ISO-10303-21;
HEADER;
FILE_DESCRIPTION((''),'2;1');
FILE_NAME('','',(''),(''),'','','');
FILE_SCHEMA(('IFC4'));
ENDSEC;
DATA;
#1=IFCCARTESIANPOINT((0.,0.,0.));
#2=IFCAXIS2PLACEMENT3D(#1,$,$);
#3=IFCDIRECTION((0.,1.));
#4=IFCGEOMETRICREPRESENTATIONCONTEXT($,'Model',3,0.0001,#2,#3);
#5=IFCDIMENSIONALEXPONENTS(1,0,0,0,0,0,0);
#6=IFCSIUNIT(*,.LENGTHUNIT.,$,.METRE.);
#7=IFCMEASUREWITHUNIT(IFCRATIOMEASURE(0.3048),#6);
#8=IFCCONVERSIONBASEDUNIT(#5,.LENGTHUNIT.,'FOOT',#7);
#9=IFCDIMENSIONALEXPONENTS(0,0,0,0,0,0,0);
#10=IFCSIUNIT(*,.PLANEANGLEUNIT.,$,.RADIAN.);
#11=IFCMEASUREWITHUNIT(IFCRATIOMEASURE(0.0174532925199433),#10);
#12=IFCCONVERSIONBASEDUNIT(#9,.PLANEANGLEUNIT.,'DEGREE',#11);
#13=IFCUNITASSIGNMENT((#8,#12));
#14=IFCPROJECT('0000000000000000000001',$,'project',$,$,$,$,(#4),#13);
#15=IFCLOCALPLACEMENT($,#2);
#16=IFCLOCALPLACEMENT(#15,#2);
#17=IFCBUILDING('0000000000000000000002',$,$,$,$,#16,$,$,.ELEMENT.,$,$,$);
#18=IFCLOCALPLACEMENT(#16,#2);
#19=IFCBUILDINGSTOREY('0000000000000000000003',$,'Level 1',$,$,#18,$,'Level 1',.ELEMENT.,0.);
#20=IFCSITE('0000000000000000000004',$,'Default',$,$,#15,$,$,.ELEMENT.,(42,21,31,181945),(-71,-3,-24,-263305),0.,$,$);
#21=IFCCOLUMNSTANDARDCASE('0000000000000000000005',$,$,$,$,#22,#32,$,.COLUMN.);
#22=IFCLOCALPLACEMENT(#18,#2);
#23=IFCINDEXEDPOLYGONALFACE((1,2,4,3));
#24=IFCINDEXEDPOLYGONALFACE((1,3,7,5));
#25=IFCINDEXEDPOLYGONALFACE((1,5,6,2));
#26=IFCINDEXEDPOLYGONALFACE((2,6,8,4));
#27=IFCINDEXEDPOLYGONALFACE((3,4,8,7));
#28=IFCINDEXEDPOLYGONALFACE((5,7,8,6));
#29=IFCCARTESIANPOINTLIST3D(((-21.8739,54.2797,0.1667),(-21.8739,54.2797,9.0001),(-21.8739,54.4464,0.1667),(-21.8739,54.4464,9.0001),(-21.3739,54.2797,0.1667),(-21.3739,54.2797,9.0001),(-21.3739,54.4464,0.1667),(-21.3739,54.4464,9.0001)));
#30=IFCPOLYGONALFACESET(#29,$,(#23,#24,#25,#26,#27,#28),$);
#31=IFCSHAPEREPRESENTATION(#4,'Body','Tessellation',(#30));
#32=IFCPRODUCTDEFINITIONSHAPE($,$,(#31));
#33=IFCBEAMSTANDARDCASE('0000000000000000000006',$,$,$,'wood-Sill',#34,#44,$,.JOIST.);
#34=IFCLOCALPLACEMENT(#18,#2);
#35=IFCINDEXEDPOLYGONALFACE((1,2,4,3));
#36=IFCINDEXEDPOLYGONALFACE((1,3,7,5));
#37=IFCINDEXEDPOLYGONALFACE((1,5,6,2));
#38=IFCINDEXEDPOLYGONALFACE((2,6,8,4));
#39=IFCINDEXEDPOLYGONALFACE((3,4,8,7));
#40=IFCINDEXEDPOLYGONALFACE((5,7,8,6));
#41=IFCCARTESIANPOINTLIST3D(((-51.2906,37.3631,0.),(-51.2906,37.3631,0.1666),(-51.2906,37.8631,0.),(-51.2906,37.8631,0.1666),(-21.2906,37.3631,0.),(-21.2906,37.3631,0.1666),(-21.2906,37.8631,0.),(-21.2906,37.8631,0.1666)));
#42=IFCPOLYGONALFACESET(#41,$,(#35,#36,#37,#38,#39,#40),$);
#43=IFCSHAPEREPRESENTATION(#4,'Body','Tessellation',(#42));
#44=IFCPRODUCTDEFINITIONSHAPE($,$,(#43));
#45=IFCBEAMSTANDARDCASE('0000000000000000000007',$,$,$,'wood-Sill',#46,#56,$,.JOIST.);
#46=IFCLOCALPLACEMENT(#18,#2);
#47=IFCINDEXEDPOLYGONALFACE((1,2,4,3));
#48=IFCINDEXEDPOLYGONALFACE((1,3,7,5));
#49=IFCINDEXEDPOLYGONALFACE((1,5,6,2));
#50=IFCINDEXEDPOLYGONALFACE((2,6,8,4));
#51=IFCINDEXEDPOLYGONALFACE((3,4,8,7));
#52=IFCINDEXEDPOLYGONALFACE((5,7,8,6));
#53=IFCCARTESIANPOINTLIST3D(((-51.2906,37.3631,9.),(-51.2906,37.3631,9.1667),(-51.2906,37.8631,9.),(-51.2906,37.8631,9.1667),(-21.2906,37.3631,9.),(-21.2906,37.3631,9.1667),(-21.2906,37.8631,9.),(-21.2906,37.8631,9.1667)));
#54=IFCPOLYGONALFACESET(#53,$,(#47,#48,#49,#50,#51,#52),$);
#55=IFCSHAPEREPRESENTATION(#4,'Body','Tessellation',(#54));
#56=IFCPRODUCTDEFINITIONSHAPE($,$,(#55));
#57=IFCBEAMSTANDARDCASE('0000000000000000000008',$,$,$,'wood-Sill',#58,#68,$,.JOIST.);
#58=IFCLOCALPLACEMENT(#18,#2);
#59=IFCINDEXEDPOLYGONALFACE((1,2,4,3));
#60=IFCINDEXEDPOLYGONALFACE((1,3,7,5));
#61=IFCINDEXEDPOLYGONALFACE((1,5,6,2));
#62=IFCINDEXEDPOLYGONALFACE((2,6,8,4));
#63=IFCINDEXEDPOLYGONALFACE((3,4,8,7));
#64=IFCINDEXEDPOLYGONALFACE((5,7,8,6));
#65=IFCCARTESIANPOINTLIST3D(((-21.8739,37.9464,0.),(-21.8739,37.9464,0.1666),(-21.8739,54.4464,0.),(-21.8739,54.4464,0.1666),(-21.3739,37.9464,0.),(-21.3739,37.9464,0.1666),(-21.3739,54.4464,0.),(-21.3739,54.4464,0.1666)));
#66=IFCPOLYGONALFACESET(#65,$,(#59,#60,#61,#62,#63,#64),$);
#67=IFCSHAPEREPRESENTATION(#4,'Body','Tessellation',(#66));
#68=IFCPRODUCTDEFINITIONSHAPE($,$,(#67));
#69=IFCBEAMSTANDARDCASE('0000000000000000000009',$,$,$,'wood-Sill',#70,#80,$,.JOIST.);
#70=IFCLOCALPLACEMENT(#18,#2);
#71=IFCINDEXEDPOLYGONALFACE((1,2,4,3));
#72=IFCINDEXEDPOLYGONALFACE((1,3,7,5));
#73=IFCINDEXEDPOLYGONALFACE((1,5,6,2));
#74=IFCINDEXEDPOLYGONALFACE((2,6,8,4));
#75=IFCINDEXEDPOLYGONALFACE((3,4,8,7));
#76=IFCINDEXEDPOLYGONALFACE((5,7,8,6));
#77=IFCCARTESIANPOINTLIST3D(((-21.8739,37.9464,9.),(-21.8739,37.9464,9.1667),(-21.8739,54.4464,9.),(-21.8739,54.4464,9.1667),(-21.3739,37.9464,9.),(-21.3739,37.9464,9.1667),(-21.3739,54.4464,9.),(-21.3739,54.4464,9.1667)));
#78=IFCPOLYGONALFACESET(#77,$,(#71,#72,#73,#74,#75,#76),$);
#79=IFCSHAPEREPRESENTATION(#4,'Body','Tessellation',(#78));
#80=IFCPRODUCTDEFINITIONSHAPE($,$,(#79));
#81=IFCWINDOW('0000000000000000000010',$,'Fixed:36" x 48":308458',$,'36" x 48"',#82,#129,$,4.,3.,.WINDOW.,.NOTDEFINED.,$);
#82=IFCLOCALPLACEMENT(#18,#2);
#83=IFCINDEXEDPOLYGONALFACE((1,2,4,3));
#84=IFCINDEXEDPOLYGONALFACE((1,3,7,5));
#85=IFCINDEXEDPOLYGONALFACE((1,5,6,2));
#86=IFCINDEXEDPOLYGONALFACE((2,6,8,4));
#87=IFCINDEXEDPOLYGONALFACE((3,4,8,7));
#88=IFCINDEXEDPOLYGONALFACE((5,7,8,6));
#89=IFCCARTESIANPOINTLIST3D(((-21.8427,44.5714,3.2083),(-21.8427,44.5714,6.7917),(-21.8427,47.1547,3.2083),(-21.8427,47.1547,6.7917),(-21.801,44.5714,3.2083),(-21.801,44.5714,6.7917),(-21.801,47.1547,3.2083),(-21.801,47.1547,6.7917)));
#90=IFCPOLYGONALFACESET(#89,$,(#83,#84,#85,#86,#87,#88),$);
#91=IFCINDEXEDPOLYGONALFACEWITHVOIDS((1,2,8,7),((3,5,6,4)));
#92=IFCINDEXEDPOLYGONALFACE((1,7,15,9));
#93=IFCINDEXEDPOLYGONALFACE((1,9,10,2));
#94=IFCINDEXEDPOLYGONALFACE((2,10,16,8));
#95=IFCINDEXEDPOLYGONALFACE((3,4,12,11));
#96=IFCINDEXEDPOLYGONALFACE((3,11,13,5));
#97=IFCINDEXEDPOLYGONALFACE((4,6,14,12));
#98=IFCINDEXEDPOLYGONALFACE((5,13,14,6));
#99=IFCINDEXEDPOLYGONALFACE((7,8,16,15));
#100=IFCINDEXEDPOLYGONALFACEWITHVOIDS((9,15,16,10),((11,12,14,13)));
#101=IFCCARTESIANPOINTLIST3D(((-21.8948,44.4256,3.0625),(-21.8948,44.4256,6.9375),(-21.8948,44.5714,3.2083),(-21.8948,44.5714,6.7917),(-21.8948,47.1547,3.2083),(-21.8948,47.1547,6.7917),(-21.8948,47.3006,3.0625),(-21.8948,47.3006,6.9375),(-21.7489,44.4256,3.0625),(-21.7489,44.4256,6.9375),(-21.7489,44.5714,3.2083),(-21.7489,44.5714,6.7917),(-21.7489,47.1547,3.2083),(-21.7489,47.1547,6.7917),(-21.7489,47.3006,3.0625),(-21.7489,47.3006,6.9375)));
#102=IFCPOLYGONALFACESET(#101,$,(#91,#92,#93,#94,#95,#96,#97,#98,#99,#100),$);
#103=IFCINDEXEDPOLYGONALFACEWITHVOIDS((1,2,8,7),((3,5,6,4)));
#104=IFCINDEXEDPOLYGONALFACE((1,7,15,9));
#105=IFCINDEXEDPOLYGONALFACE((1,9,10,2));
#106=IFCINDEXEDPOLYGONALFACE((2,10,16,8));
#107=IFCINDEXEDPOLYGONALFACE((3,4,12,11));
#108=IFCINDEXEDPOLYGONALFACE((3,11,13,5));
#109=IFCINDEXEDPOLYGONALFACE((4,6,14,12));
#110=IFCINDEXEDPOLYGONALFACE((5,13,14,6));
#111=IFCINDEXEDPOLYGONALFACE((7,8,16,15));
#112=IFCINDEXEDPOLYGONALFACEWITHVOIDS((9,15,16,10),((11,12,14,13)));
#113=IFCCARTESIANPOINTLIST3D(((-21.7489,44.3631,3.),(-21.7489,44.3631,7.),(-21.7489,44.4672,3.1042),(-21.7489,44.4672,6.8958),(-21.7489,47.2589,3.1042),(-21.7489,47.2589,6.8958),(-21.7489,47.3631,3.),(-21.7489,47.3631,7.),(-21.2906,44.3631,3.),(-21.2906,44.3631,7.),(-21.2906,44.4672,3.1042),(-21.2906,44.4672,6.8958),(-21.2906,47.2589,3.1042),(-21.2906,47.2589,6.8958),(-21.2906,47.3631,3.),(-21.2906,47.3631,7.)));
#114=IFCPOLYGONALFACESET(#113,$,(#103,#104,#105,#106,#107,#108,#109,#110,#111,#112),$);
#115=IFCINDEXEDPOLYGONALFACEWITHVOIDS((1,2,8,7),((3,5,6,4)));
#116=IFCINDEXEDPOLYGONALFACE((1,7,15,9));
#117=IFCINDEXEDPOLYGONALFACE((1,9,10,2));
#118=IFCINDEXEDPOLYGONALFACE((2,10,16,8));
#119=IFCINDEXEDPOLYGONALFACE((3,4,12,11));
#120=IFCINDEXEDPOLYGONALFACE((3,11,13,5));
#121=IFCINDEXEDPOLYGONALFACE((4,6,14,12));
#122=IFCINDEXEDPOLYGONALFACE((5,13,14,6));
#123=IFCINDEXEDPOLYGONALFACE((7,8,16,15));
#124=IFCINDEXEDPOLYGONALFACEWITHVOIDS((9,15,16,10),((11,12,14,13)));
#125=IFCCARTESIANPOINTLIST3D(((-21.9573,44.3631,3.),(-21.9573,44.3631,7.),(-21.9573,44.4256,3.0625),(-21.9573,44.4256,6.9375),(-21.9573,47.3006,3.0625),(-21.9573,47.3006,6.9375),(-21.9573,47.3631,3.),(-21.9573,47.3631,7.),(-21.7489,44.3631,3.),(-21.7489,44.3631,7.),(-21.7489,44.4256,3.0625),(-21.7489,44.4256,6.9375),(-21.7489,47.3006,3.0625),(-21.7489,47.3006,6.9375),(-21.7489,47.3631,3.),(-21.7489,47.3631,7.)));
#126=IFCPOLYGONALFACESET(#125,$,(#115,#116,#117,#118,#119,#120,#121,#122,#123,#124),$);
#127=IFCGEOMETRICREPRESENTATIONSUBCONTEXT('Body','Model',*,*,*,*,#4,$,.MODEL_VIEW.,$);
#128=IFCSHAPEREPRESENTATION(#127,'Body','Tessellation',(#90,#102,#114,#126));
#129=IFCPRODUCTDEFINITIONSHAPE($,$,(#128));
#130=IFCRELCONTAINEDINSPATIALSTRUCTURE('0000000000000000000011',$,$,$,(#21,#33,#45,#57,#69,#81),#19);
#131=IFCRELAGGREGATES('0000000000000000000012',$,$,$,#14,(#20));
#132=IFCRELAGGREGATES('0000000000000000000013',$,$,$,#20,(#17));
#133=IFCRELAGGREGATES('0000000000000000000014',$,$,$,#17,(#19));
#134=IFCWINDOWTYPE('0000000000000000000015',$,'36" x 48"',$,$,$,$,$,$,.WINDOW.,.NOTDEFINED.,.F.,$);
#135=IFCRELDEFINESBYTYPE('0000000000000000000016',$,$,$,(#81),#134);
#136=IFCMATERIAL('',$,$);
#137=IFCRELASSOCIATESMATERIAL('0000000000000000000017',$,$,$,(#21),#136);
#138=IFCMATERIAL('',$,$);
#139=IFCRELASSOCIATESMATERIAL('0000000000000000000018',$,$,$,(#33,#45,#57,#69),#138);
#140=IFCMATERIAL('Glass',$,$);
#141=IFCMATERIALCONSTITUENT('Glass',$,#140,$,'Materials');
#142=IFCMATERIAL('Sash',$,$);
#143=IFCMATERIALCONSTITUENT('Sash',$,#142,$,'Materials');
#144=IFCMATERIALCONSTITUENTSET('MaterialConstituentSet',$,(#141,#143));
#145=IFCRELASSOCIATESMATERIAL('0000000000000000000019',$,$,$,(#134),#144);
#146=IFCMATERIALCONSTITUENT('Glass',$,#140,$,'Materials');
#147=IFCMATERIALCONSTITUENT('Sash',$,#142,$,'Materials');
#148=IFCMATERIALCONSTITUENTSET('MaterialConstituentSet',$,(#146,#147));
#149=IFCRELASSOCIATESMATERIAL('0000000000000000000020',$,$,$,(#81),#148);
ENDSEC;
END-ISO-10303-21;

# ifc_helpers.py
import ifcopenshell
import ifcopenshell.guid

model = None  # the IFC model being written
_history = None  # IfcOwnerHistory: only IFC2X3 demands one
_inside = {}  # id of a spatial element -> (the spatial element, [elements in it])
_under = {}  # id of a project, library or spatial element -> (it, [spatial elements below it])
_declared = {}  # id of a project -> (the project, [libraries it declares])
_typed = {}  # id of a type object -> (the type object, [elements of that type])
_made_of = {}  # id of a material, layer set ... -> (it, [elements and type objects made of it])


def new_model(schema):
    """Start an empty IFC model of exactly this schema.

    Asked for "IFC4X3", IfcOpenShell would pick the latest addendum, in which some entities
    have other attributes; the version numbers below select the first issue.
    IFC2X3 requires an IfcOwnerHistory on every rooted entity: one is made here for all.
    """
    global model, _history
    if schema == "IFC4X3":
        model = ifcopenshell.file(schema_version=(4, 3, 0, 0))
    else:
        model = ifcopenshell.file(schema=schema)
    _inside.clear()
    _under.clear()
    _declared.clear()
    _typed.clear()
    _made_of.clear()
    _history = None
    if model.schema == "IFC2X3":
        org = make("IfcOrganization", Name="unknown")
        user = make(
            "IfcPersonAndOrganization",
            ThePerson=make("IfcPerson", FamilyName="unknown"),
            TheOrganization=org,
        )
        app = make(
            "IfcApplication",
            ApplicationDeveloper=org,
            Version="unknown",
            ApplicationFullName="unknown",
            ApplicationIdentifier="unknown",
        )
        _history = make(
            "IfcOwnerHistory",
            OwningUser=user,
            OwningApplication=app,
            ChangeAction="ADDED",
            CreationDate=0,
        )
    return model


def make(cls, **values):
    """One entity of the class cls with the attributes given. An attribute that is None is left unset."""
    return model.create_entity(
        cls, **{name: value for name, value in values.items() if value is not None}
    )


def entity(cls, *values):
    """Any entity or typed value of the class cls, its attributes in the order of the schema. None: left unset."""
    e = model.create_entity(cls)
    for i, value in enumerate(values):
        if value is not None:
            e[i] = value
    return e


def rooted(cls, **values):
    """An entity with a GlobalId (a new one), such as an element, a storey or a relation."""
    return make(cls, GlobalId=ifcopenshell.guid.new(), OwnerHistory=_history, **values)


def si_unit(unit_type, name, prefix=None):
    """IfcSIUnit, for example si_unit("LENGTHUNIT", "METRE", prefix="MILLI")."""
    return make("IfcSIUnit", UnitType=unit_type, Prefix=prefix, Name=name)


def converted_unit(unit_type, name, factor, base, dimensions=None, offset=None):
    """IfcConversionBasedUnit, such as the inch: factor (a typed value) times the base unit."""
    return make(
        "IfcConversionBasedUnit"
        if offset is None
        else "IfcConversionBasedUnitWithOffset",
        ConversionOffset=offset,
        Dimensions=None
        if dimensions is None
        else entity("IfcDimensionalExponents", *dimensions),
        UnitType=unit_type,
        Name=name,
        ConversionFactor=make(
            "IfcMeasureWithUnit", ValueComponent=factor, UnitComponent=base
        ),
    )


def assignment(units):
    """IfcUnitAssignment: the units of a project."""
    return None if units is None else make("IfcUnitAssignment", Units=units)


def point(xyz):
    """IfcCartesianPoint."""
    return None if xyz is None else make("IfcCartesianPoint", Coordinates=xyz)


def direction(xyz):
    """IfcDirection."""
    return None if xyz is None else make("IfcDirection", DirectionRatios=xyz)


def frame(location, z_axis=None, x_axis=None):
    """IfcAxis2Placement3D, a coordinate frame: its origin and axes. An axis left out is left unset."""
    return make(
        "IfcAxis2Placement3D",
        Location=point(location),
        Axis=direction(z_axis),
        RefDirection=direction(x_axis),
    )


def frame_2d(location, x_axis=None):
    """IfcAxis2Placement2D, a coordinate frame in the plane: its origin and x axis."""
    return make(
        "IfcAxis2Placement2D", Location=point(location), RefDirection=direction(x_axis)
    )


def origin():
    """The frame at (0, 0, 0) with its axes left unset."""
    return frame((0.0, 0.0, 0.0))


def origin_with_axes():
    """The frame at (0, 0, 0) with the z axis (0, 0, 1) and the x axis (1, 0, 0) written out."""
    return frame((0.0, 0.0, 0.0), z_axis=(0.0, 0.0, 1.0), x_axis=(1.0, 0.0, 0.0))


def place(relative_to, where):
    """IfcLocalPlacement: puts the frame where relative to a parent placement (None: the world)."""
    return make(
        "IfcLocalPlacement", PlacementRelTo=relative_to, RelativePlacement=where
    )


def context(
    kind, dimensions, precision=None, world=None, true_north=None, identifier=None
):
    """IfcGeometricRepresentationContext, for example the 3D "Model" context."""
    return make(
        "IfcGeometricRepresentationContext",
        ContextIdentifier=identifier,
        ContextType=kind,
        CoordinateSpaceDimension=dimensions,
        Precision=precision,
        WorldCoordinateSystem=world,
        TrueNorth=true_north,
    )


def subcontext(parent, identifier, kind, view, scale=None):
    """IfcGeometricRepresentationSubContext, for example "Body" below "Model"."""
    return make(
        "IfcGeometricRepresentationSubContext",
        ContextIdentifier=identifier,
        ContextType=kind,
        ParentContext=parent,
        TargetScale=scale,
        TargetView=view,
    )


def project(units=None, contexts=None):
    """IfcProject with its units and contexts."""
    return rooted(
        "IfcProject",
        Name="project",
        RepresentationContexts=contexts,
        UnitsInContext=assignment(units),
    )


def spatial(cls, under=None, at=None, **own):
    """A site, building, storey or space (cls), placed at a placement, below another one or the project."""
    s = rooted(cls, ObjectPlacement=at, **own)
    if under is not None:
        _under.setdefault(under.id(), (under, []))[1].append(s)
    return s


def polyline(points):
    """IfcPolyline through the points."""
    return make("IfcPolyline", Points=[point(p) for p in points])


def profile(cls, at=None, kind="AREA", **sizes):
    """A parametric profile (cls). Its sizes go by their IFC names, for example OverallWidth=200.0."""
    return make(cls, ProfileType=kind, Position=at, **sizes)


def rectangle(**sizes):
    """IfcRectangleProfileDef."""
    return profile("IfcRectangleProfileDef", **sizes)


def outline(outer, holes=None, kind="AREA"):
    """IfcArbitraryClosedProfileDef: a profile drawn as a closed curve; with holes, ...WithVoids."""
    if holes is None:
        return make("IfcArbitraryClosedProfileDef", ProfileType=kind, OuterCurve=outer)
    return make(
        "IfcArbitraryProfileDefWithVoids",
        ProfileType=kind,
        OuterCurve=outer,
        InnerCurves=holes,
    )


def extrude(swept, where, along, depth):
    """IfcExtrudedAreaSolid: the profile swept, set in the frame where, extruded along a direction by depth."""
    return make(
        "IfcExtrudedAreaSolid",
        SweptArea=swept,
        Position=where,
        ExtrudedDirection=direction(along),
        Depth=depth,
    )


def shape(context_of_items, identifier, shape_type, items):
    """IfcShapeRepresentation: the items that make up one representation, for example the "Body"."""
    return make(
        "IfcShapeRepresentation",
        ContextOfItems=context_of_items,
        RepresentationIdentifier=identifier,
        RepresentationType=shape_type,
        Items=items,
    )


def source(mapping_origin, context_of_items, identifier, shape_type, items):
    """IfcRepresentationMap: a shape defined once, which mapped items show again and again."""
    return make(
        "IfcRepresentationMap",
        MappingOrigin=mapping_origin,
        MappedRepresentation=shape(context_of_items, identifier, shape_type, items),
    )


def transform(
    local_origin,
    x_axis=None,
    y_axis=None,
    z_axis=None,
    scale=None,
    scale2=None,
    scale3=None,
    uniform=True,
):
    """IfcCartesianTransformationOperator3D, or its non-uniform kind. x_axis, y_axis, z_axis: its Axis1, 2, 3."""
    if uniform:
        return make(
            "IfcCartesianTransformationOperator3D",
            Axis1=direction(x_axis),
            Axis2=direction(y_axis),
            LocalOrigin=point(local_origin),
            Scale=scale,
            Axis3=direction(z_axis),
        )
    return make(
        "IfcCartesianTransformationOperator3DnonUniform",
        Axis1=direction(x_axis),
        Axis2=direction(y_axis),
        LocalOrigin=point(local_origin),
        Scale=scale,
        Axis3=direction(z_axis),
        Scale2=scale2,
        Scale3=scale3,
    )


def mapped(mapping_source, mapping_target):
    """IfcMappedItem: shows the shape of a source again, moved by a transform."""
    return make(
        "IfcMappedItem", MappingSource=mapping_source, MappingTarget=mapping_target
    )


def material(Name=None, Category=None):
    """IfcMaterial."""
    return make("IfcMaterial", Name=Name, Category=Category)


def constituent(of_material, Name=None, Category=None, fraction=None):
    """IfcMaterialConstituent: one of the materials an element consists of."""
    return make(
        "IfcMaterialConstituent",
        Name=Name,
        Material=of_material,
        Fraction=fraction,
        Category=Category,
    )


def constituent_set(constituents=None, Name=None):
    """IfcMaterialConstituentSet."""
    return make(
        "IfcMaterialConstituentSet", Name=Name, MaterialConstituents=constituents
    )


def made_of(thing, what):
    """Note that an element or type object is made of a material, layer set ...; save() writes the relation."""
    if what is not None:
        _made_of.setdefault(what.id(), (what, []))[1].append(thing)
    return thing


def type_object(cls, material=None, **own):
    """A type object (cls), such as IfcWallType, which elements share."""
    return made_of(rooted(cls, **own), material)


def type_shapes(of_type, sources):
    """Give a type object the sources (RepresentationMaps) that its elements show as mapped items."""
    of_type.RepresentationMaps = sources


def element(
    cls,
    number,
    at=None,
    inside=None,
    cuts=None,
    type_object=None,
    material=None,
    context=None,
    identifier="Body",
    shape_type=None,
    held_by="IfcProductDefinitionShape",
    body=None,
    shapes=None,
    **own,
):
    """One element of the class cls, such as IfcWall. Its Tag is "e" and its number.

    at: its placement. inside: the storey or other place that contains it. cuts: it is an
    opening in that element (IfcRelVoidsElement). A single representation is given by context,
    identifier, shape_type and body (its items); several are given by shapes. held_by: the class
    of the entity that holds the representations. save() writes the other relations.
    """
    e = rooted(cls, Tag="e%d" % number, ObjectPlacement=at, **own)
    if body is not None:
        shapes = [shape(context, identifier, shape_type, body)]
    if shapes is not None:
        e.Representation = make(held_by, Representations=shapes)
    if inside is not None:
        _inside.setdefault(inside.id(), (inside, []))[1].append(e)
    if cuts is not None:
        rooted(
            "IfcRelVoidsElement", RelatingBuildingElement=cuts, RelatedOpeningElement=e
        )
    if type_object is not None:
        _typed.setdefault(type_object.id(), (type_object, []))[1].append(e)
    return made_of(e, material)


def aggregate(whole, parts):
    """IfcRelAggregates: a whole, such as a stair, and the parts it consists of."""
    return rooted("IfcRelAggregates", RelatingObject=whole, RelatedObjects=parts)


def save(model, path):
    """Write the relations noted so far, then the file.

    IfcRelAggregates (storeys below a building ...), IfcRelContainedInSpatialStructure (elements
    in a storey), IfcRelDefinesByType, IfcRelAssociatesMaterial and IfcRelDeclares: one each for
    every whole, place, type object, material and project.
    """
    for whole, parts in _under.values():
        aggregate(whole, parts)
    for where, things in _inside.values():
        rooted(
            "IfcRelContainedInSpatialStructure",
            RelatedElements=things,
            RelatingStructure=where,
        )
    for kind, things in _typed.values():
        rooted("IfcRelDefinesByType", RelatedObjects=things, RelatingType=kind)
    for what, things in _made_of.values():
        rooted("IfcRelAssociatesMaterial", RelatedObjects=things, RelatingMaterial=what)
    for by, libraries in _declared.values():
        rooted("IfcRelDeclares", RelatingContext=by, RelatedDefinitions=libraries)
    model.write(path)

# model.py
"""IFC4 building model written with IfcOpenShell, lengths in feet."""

from ifc_helpers import new_model, entity, si_unit, converted_unit, direction, frame, frame_2d, origin, origin_with_axes, place, context, subcontext, project, spatial, polyline, rectangle, outline, extrude, source, transform, mapped, material, constituent, constituent_set, type_object, type_shapes, element, save


model = new_model("IFC4")

# Units and contexts
model_context = context("Model", 3, precision=0.0001, world=origin(), true_north=direction((0.0, 1.0)))
body_context = subcontext(model_context, "Body", "Model", "MODEL_VIEW")
ifc_project = project(units=[converted_unit("LENGTHUNIT", "FOOT", entity("IfcRatioMeasure", 0.3048), si_unit("LENGTHUNIT", "METRE"), dimensions=[1, 0, 0, 0, 0, 0, 0]), converted_unit("PLANEANGLEUNIT", "DEGREE", entity("IfcRatioMeasure", 0.0174532925199433), si_unit("PLANEANGLEUNIT", "RADIAN"), dimensions=[0, 0, 0, 0, 0, 0, 0])], contexts=[model_context])

# Site, building, storey
site_placement = place(None, origin())
site = spatial("IfcSite", under=ifc_project, at=site_placement, Name="Default", CompositionType="ELEMENT", RefLatitude=(42, 21, 31, 181945), RefLongitude=(-71, -3, -24, -263305), RefElevation=0.0)
building_placement = place(site_placement, origin())
building = spatial("IfcBuilding", under=site, at=building_placement, CompositionType="ELEMENT")
storey_placement = place(building_placement, origin())
storey = spatial("IfcBuildingStorey", under=building, at=storey_placement, Name="Level 1", LongName="Level 1", CompositionType="ELEMENT", Elevation=0.0)

# Column
ifc_material_1 = material(Name="")
placement_1 = place(storey_placement, frame((-21.6239, 54.4464, 0.0), z_axis=(0.0, 0.0, 1.0), x_axis=(0.0, -1.0, 0.0)))
for number, where, z_axis, x_axis in (
    (1, (0.0833, 0.0, 0.1667), (0.0, 0.0, 1.0), (1.0, 0.0, 0.0)),
):
    element("IfcColumnStandardCase", number, at=place(placement_1, frame(where, z_axis=z_axis, x_axis=x_axis)), inside=storey, material=ifc_material_1, PredefinedType="COLUMN", context=model_context, shape_type="SweptSolid", body=[
        extrude(rectangle(XDim=0.1667, YDim=0.5), origin(), (0.0, 0.0, 1.0), 8.8334),
    ])

# Beams
ifc_material_2 = material(Name="")
placement_2 = place(storey_placement, frame((-21.2906, 37.6131, 0.0), z_axis=(0.0, 0.0, 1.0), x_axis=(-1.0, 0.0, 0.0)))
for number, where, z_axis, x_axis in (
    (2, (0.0, 0.0, 0.0833), (1.0, 0.0, 0.0), (0.0, 0.0, 1.0)),
    (3, (0.0, 0.0, 9.0834), (1.0, 0.0, 0.0), (0.0, 0.0, 1.0)),
):
    element("IfcBeamStandardCase", number, at=place(placement_2, frame(where, z_axis=z_axis, x_axis=x_axis)), inside=storey, material=ifc_material_2, ObjectType="wood-Sill", PredefinedType="JOIST", context=model_context, shape_type="SweptSolid", body=[
        extrude(rectangle(XDim=0.1667, YDim=0.5), origin_with_axes(), (0.0, 0.0, 1.0), 30.0),
    ])
for number, where, z_axis, x_axis in (
    (4, (0.0, 0.0, 0.0833), (1.0, 0.0, 0.0), (0.0, 0.0, 1.0)),
    (5, (0.0, 0.0, 9.0834), (1.0, 0.0, 0.0), (0.0, 0.0, 1.0)),
):
    element("IfcBeamStandardCase", number, at=place(placement_1, frame(where, z_axis=z_axis, x_axis=x_axis)), inside=storey, material=ifc_material_2, ObjectType="wood-Sill", PredefinedType="JOIST", context=model_context, shape_type="SweptSolid", body=[
        extrude(rectangle(XDim=0.1667, YDim=0.5), origin_with_axes(), (0.0, 0.0, 1.0), 16.5),
    ])

# Window
ifc_material_3 = material(Name="Glass")
ifc_constituent_1 = constituent(ifc_material_3, Name="Glass", Category="Materials")
ifc_material_4 = material(Name="Sash")
ifc_constituent_2 = constituent(ifc_material_4, Name="Sash", Category="Materials")
ifc_constituent_set_1 = constituent_set(constituents=[ifc_constituent_1, ifc_constituent_2], Name="MaterialConstituentSet")
ifc_constituent_3 = constituent(ifc_material_3, Name="Glass", Category="Materials")
ifc_constituent_4 = constituent(ifc_material_4, Name="Sash", Category="Materials")
ifc_constituent_set_2 = constituent_set(constituents=[ifc_constituent_3, ifc_constituent_4], Name="MaterialConstituentSet")
window_type = type_object("IfcWindowType", Name="36\" x 48\"", ParameterTakesPrecedence=False, PartitioningType="NOTDEFINED", PredefinedType="WINDOW", material=ifc_constituent_set_2)
shared_shape = source(origin(), body_context, "Body", "SweptSolid", [
    extrude(rectangle(XDim=0.0417, YDim=2.5833, at=frame_2d((0.0, 0.0), x_axis=(1.0, 0.0))), frame((1.5, 0.5312, 0.2083), z_axis=(0.0, 0.0, 1.0), x_axis=(0.0, 1.0, 0.0)), (0.0, 0.0, 1.0), 3.5833),
    extrude(outline(polyline([(-1.4375, -1.9375), (1.4375, -1.9375), (1.4375, 1.9375), (-1.4375, 1.9375), (-1.4375, -1.9375)]), holes=[polyline([(-1.2917, -1.7917), (-1.2917, 1.7917), (1.2917, 1.7917), (1.2917, -1.7917), (-1.2917, -1.7917)])]), frame((1.5, 0.4583, 2.0), z_axis=(0.0, 1.0, 0.0), x_axis=(1.0, 0.0, 0.0)), (0.0, 0.0, 1.0), 0.1458),
    extrude(outline(polyline([(-1.5, -2.0), (1.5, -2.0), (1.5, 2.0), (-1.5, 2.0), (-1.5, -2.0)]), holes=[polyline([(-1.3958, -1.8958), (-1.3958, 1.8958), (1.3958, 1.8958), (1.3958, -1.8958), (-1.3958, -1.8958)])]), frame((1.5, 0.0, 2.0), z_axis=(0.0, 1.0, 0.0), x_axis=(1.0, 0.0, 0.0)), (0.0, 0.0, 1.0), 0.4583),
    extrude(outline(polyline([(-2.0, -1.5), (2.0, -1.5), (2.0, 1.5), (-2.0, 1.5), (-2.0, -1.5)]), holes=[polyline([(-1.9375, -1.4375), (-1.9375, 1.4375), (1.9375, 1.4375), (1.9375, -1.4375), (-1.9375, -1.4375)])]), frame((1.5, 0.4583, 2.0), z_axis=(0.0, 1.0, 0.0), x_axis=(0.0, 0.0, -1.0)), (0.0, 0.0, 1.0), 0.2083),
])
type_shapes(window_type, [shared_shape])
placement_3 = place(placement_1, frame((10.0833, 0.3333, 3.0)))
window_placement = place(placement_3, frame((0.0, 0.0, 0.0), z_axis=(0.0, 0.0, 1.0), x_axis=(-1.0, 0.0, 0.0)))
element("IfcWindow", 6, at=window_placement, inside=storey, type_object=window_type, material=ifc_constituent_set_1, Name="Fixed:36\" x 48\":308458", ObjectType="36\" x 48\"", OverallHeight=4.0, OverallWidth=3.0, PartitioningType="NOTDEFINED", PredefinedType="WINDOW", context=body_context, shape_type="MappedRepresentation", body=[
    mapped(shared_shape, transform((0.0, 0.0, 0.0), scale=1.0)),
])

save(model, "model.ifc")
